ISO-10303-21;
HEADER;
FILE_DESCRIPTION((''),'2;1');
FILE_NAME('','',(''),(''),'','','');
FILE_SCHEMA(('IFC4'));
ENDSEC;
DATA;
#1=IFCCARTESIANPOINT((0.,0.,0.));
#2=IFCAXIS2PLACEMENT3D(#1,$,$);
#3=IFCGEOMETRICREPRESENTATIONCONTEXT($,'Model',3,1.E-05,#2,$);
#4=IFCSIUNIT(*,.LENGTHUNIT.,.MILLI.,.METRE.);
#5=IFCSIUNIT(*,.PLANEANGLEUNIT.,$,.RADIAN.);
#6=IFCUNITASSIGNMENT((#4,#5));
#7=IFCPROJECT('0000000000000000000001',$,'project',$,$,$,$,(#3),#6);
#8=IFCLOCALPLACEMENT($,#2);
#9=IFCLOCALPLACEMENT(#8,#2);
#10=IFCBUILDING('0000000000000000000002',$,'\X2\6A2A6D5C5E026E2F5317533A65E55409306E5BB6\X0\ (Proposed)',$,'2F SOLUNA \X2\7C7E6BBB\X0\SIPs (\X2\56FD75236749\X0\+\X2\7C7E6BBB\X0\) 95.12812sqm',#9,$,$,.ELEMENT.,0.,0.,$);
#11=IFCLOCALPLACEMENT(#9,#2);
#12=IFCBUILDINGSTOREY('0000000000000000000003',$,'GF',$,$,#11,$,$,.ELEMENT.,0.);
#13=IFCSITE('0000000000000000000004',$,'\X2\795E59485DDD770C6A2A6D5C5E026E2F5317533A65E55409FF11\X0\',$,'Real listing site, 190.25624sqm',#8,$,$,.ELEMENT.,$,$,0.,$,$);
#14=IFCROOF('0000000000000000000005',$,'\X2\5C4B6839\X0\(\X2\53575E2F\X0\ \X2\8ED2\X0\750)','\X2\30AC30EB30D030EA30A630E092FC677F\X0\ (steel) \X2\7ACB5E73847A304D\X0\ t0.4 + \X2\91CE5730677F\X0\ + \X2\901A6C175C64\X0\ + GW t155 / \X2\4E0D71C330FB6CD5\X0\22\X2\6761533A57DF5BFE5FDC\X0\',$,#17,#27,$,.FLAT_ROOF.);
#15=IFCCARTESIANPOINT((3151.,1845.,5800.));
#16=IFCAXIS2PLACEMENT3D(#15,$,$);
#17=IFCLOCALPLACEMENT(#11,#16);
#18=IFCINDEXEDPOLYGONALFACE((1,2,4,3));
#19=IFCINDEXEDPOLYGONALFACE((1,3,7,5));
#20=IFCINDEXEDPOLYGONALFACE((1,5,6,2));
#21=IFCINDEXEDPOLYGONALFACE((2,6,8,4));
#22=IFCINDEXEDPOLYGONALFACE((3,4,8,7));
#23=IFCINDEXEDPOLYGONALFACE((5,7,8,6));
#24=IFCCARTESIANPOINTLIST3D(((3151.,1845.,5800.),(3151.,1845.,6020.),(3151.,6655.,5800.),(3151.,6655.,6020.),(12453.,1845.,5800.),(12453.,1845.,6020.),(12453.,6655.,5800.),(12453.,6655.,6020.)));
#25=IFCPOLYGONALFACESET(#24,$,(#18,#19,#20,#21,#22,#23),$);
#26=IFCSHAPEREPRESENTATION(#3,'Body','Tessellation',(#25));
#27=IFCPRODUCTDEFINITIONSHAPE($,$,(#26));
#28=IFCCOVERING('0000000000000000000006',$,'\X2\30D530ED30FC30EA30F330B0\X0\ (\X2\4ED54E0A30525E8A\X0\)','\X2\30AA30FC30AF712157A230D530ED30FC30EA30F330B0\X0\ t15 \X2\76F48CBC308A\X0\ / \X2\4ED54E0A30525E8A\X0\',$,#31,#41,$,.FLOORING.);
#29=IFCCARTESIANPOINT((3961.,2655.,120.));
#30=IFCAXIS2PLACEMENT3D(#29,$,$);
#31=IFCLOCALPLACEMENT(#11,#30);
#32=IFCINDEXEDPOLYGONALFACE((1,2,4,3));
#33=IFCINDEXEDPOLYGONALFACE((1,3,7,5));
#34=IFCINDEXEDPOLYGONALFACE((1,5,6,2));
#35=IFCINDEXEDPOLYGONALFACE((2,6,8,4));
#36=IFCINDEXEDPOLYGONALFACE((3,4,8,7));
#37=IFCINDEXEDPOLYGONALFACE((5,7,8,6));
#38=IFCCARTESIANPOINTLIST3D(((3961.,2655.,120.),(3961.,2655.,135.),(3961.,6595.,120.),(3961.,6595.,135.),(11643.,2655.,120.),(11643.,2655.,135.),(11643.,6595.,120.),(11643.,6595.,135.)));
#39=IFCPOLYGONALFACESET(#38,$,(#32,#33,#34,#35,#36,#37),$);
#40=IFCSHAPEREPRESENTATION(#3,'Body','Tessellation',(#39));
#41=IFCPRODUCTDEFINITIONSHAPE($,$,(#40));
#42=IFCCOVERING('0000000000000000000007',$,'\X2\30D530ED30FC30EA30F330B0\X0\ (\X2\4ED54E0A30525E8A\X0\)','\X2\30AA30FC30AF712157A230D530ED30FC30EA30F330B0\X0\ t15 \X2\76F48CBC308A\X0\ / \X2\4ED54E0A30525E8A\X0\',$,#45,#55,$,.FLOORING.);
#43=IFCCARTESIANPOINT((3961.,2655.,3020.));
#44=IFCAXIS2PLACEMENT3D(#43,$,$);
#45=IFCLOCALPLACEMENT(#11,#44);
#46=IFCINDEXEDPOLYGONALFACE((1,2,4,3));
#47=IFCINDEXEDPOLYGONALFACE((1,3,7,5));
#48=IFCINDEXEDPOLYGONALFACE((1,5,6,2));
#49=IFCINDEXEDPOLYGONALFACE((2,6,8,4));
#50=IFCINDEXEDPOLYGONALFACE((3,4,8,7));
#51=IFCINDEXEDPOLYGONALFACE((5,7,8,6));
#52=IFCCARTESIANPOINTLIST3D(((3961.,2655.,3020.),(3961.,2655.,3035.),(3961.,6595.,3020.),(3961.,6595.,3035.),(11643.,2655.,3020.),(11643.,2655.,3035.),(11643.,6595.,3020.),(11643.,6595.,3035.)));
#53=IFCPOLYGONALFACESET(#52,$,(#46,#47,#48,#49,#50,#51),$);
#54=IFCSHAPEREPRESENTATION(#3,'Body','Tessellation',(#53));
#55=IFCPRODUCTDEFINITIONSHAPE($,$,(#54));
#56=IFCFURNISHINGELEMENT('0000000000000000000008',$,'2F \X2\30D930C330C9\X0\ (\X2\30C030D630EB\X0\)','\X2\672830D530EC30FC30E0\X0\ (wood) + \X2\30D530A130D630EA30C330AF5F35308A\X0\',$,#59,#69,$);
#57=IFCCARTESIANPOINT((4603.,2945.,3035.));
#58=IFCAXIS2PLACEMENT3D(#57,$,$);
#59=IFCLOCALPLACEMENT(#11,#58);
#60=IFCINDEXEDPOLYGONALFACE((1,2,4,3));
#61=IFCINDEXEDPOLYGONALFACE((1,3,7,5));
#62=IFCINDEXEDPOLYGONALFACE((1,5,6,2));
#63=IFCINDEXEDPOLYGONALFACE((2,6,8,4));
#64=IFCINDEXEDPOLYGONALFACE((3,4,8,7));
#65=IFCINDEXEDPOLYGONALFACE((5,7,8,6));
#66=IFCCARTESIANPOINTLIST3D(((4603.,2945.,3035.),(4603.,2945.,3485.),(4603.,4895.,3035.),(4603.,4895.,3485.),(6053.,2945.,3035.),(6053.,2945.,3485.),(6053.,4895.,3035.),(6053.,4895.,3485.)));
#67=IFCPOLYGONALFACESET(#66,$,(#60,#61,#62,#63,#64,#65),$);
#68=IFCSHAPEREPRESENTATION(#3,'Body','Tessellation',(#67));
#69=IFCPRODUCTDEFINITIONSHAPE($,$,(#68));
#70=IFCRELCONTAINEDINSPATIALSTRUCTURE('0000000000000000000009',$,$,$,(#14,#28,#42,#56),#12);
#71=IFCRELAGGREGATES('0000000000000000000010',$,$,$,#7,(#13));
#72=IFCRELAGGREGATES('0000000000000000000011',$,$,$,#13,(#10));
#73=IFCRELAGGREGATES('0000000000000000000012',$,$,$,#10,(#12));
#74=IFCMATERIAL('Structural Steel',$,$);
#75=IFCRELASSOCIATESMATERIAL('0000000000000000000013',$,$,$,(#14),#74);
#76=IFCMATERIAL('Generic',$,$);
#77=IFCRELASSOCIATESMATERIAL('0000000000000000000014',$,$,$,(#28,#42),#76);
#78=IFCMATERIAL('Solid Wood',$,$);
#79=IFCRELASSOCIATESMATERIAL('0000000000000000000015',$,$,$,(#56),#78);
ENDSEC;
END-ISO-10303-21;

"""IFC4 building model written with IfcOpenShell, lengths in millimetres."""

from ifc_helpers import new_model, si_unit, frame, frame_2d, origin, place, context, project, spatial, rectangle, extrude, material, element, save


model = new_model("IFC4")

# Units and contexts
model_context = context("Model", 3, precision=1e-05, world=origin())
ifc_project = project(units=[si_unit("LENGTHUNIT", "METRE", prefix="MILLI"), si_unit("PLANEANGLEUNIT", "RADIAN")], contexts=[model_context])

# Site, building, storey
site_placement = place(None, origin())
site = spatial("IfcSite", under=ifc_project, at=site_placement, Name="神奈川県横浜市港北区日吉１", ObjectType="Real listing site, 190.25624sqm", CompositionType="ELEMENT", RefElevation=0.0)
building_placement = place(site_placement, origin())
building = spatial("IfcBuilding", under=site, at=building_placement, Name="横浜市港北区日吉の家 (Proposed)", ObjectType="2F SOLUNA 籾殻SIPs (国産杉+籾殻) 95.12812sqm", CompositionType="ELEMENT", ElevationOfRefHeight=0.0, ElevationOfTerrain=0.0)
storey_placement = place(building_placement, origin())
storey = spatial("IfcBuildingStorey", under=building, at=storey_placement, Name="GF", CompositionType="ELEMENT", Elevation=0.0)

# Shared definitions
ifc_material_1 = material(Name="Solid Wood")

# Roof
ifc_material_2 = material(Name="Structural Steel")
for number, where, name in (
    (1, (3151.0, 1845.0, 5800.0), "屋根(南帯 軒750)"),
):
    element("IfcRoof", number, at=place(storey_placement, frame(where)), inside=storey, material=ifc_material_2, Name=name, Description="ガルバリウム鋼板 (steel) 立平葺き t0.4 + 野地板 + 通気層 + GW t155 / 不燃・法22条区域対応", PredefinedType="FLAT_ROOF", context=model_context, shape_type="SweptSolid", body=[
        extrude(rectangle(XDim=9302.0, YDim=4810.0, at=frame_2d((4651.0, 2405.0))), frame((3151.0, 1845.0, 5800.0)), (0.0, 0.0, 1.0), 220.0),
    ])

# Coverings
ifc_material_3 = material(Name="Generic")
covering_1_placement = place(storey_placement, frame((3961.0, 2655.0, 120.0)))
element("IfcCovering", 2, at=covering_1_placement, inside=storey, material=ifc_material_3, Name="フローリング (仕上げ床)", Description="オーク無垢フローリング t15 直貼り / 仕上げ床", PredefinedType="FLOORING", context=model_context, shape_type="SweptSolid", body=[
    extrude(rectangle(XDim=7682.0, YDim=3940.0, at=frame_2d((3841.0, 1970.0))), frame((3961.0, 2655.0, 120.0)), (0.0, 0.0, 1.0), 15.0),
])
covering_2_placement = place(storey_placement, frame((3961.0, 2655.0, 3020.0)))
element("IfcCovering", 3, at=covering_2_placement, inside=storey, material=ifc_material_3, Name="フローリング (仕上げ床)", Description="オーク無垢フローリング t15 直貼り / 仕上げ床", PredefinedType="FLOORING", context=model_context, shape_type="SweptSolid", body=[
    extrude(rectangle(XDim=7682.0, YDim=3940.0, at=frame_2d((3841.0, 1970.0))), frame((3961.0, 2655.0, 3020.0)), (0.0, 0.0, 1.0), 15.0),
])

# Furnishing element
furnishing_placement = place(storey_placement, frame((4603.0, 2945.0, 3035.0)))
element("IfcFurnishingElement", 4, at=furnishing_placement, inside=storey, material=ifc_material_1, Name="2F ベッド (ダブル)", Description="木フレーム (wood) + ファブリック張り", context=model_context, shape_type="SweptSolid", body=[
    extrude(rectangle(XDim=1450.0, YDim=1950.0, at=frame_2d((725.0, 975.0))), frame((4603.0, 2945.0, 3035.0)), (0.0, 0.0, 1.0), 450.0),
])

save(model, "model.ifc")
